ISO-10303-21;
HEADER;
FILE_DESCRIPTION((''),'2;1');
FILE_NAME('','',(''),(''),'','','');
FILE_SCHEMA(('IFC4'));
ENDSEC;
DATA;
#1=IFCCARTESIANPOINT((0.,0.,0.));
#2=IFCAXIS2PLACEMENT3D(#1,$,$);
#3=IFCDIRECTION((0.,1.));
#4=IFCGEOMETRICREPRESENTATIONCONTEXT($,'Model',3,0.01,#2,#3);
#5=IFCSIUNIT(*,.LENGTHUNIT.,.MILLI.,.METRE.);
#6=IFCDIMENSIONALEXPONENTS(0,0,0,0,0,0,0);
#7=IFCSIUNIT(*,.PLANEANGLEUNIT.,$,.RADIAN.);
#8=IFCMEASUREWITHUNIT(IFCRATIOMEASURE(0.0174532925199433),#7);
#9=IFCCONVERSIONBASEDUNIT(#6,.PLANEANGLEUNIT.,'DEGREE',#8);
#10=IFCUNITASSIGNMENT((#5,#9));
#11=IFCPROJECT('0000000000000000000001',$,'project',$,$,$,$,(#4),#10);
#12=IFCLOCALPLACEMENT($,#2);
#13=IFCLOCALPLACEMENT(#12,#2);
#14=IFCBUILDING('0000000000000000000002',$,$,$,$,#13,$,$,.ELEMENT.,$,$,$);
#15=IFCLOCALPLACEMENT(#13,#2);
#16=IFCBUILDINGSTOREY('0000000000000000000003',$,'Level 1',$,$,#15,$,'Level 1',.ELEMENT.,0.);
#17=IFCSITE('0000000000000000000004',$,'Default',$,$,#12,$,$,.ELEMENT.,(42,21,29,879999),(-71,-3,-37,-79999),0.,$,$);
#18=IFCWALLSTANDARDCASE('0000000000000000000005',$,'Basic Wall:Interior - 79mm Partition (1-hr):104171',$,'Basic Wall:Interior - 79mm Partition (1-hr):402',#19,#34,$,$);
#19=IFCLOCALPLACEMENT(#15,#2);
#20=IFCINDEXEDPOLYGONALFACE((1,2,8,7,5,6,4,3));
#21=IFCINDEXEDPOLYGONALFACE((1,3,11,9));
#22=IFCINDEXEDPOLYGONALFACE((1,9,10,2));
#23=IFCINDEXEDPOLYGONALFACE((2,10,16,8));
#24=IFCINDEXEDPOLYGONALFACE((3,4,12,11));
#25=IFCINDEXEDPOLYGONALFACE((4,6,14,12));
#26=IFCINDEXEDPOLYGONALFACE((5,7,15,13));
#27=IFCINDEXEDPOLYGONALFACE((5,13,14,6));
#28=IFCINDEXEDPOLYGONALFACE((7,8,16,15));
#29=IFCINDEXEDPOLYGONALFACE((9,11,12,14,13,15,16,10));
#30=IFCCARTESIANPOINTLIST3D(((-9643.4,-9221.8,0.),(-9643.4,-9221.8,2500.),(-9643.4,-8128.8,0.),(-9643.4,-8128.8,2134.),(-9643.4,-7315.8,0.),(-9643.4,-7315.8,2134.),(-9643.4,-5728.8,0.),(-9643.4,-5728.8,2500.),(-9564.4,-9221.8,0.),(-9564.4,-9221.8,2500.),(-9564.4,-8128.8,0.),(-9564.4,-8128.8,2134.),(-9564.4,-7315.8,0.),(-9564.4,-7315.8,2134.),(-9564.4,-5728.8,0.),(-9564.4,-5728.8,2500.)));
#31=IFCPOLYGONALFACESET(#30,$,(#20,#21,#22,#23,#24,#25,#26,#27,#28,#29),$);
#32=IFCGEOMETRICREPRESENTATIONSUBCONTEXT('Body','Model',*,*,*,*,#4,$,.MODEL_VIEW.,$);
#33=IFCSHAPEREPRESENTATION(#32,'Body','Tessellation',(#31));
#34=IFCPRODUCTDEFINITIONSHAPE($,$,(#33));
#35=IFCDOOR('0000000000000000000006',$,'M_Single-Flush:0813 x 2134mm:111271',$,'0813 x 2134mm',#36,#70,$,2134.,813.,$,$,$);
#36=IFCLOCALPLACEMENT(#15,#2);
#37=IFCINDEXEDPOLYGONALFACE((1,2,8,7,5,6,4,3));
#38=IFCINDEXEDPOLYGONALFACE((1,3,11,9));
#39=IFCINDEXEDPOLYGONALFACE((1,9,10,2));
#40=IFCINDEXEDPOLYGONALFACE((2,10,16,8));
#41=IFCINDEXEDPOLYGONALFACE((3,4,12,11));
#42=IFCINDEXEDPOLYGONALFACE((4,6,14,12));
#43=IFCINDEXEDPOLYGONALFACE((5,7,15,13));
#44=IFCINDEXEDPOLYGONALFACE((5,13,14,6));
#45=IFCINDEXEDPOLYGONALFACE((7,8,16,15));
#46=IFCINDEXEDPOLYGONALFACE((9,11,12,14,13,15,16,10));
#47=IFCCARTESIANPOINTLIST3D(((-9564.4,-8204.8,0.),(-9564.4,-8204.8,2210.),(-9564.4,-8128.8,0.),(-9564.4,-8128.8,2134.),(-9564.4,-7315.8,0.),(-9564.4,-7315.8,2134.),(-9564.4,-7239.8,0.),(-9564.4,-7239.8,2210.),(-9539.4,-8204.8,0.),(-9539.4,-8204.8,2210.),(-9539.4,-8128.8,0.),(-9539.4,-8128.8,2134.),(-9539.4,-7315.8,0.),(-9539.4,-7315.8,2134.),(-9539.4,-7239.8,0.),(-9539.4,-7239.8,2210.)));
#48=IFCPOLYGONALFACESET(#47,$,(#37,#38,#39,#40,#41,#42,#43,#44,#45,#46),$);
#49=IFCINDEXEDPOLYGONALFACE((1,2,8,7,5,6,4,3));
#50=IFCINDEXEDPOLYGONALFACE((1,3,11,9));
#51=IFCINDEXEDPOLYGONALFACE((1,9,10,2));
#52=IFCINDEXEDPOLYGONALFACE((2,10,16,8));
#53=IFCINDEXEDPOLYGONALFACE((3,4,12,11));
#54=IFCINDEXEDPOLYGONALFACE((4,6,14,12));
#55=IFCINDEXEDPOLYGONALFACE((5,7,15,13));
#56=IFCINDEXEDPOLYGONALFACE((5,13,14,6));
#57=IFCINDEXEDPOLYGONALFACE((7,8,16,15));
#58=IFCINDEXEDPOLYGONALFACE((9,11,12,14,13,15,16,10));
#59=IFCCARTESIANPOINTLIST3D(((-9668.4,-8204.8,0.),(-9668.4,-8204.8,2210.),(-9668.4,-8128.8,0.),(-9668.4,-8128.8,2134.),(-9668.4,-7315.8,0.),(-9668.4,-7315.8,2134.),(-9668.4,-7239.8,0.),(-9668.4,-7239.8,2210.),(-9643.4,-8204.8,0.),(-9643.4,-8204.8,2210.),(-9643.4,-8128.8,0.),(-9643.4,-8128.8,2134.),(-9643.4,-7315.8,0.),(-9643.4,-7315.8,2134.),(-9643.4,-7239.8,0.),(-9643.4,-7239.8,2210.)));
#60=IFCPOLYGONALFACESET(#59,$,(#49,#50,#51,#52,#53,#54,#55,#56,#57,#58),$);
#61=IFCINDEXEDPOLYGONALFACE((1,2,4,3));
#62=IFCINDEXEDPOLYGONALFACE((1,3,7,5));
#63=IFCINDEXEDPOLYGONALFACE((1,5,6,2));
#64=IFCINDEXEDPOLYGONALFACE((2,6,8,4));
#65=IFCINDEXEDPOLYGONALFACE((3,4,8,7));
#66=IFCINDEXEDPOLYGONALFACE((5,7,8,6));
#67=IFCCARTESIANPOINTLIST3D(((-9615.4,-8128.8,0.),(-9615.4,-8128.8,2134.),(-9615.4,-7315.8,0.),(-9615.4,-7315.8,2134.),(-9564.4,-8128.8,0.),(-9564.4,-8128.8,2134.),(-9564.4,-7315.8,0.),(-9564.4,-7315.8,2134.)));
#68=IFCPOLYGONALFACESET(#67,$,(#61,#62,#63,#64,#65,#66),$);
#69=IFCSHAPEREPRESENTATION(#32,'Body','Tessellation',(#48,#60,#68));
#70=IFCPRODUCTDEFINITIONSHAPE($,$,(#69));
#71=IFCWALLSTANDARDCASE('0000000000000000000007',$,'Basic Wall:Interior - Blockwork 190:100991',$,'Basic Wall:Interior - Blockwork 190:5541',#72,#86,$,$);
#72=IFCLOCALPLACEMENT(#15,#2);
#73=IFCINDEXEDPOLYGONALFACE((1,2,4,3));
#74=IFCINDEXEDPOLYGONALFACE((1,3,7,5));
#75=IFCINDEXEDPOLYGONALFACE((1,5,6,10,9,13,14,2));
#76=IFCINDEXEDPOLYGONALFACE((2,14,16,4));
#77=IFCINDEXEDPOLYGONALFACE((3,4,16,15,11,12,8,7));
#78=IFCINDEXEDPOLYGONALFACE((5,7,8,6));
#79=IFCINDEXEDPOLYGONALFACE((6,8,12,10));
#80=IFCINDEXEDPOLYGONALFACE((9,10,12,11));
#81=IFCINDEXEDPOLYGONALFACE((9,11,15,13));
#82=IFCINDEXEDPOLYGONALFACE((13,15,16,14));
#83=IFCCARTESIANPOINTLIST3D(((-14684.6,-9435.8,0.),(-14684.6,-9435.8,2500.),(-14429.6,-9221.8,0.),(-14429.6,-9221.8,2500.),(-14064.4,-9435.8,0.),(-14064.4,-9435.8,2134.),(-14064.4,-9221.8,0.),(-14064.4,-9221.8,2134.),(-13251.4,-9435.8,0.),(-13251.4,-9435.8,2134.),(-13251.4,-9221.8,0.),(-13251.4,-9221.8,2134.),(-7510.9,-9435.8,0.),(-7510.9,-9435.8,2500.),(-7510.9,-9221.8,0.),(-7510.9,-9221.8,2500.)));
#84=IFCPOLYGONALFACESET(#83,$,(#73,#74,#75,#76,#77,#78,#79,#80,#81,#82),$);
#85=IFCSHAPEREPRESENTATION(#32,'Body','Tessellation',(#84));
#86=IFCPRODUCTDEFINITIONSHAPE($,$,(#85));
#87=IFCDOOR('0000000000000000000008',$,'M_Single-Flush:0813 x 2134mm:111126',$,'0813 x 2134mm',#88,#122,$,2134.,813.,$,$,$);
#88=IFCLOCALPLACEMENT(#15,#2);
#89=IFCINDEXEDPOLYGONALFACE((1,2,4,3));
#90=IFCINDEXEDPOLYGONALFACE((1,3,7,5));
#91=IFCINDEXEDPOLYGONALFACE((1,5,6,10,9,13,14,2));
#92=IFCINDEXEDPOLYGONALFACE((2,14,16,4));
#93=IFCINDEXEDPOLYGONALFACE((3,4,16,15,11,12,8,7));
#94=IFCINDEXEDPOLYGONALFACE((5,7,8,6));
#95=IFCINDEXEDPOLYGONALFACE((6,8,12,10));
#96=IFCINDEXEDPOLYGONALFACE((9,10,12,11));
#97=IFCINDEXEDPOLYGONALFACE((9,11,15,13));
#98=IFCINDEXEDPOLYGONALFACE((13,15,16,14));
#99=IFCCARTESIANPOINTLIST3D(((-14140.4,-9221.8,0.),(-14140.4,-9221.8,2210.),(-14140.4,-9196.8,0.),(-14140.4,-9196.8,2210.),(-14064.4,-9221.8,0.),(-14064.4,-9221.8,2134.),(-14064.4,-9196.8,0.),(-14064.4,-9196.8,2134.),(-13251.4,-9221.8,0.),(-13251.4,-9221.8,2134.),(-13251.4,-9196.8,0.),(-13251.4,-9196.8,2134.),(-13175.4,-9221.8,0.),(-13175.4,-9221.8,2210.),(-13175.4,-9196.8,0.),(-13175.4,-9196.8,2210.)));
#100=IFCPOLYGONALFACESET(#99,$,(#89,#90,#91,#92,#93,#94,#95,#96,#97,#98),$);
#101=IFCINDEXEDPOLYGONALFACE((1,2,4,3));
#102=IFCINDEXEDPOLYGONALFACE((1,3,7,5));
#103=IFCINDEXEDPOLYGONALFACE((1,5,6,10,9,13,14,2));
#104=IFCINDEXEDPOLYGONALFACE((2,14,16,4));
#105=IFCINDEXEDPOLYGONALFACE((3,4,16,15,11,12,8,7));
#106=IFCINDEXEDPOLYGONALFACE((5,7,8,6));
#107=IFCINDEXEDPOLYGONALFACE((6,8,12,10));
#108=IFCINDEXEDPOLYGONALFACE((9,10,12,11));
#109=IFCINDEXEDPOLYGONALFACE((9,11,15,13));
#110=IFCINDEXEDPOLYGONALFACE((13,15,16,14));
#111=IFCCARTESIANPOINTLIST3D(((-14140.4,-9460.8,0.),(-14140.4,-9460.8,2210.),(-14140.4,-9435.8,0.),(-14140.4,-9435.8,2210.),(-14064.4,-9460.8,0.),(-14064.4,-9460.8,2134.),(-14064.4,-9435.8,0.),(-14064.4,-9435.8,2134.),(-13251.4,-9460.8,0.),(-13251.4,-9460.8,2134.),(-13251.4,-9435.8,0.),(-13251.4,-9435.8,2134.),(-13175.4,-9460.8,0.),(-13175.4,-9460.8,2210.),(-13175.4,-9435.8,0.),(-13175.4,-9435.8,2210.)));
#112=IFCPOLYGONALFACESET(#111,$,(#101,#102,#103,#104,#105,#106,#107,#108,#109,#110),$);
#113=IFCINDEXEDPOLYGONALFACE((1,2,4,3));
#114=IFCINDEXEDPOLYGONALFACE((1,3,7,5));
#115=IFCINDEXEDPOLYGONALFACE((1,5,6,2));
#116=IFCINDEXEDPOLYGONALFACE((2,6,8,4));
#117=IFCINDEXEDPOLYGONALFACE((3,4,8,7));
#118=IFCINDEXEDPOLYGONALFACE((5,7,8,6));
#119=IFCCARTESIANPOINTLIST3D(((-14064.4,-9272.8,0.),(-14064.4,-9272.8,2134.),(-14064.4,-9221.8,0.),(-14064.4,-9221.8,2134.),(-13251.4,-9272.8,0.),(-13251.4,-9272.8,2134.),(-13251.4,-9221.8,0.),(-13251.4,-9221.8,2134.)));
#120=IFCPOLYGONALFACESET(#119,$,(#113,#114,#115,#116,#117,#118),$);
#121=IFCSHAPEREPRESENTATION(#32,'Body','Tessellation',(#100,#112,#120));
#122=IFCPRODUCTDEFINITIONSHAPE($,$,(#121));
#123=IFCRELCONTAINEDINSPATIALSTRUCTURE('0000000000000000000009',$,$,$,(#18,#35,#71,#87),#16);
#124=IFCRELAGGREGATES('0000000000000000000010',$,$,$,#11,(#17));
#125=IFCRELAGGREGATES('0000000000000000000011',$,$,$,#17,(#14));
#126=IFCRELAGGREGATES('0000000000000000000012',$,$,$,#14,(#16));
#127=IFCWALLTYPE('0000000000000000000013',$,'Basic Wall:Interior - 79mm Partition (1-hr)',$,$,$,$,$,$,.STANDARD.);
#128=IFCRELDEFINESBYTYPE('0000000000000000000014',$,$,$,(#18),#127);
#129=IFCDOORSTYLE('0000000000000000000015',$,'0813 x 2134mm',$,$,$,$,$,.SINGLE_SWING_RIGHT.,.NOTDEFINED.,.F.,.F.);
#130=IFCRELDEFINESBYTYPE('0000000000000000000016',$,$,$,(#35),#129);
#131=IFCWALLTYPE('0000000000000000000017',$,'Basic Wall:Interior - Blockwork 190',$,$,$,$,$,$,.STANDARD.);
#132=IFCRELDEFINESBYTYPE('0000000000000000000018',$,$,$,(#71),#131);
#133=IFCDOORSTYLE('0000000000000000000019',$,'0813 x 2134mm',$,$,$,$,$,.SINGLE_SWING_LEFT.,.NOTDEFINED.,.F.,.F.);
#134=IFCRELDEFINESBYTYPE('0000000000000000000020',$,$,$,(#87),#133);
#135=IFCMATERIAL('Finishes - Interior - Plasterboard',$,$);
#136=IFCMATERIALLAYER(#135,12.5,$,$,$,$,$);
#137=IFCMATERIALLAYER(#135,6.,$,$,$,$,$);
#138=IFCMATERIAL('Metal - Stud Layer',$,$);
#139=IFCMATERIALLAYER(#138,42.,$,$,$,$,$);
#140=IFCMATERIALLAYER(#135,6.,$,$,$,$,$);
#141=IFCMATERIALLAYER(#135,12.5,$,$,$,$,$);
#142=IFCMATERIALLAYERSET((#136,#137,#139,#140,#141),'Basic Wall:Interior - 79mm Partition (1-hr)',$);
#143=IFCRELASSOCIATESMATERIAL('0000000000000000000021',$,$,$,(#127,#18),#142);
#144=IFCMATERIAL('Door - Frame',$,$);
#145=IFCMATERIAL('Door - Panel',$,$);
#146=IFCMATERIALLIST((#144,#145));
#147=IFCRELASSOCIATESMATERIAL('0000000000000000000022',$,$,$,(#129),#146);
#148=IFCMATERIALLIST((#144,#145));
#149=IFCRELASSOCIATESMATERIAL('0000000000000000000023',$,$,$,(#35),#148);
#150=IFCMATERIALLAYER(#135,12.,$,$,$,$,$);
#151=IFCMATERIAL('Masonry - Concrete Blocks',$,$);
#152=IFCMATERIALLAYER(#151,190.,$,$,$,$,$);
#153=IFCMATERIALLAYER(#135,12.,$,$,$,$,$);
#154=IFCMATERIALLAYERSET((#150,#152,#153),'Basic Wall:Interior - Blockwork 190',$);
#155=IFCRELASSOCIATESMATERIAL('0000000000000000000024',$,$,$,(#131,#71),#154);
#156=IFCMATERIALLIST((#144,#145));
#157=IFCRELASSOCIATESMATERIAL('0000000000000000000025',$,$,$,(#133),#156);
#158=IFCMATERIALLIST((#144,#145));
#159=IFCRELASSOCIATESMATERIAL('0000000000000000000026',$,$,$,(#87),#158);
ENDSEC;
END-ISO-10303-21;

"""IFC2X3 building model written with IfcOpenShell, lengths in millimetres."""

from ifc_helpers import new_model, entity, si_unit, converted_unit, direction, frame, frame_2d, origin, origin_2d_with_axis, place, context, subcontext, project, spatial, polyline, rectangle, outline, extrude, source, transform, mapped, material, material_list, layer, layer_set, layer_usage, type_object, type_shapes, element, fill, save


model = new_model("IFC2X3")

# Units and contexts
model_context = context("Model", 3, precision=0.01, world=origin(), true_north=direction((0.0, 1.0)))
body_context = subcontext(model_context, "Body", "Model", "MODEL_VIEW")
ifc_project = project(units=[si_unit("LENGTHUNIT", "METRE", prefix="MILLI"), converted_unit("PLANEANGLEUNIT", "DEGREE", entity("IfcRatioMeasure", 0.0174532925199433), si_unit("PLANEANGLEUNIT", "RADIAN"), dimensions=[0, 0, 0, 0, 0, 0, 0])], contexts=[model_context])

# Site, building, storey
site_placement = place(None, origin())
site = spatial("IfcSite", under=ifc_project, at=site_placement, Name="Default", CompositionType="ELEMENT", RefLatitude=(42, 21, 29, 879999), RefLongitude=(-71, -3, -37, -79999), RefElevation=0.0)
building_placement = place(site_placement, origin())
building = spatial("IfcBuilding", under=site, at=building_placement, CompositionType="ELEMENT")
storey_placement = place(building_placement, origin())
storey = spatial("IfcBuildingStorey", under=building, at=storey_placement, Name="Level 1", LongName="Level 1", CompositionType="ELEMENT", Elevation=0.0)

# Shared definitions
ifc_material_1 = material(Name="Door - Frame")
ifc_material_2 = material(Name="Door - Panel")

# Shared definitions
ifc_material_3 = material(Name="Finishes - Interior - Plasterboard")
ifc_layer_1 = layer(ifc_material_3, 12.5)
ifc_layer_2 = layer(ifc_material_3, 6.0)
ifc_material_4 = material(Name="Metal - Stud Layer")
ifc_layer_3 = layer(ifc_material_4, 42.0)
ifc_layer_4 = layer(ifc_material_3, 6.0)
ifc_layer_5 = layer(ifc_material_3, 12.5)
ifc_layer_set_1 = layer_set([ifc_layer_1, ifc_layer_2, ifc_layer_3, ifc_layer_4, ifc_layer_5], Name="Basic Wall:Interior - 79mm Partition (1-hr)")
wall_type_1 = type_object("IfcWallType", Name="Basic Wall:Interior - 79mm Partition (1-hr)", PredefinedType="STANDARD", material=ifc_layer_set_1)

# Walls, openings, doors
ifc_layer_usage_1 = layer_usage(ifc_layer_set_1, "AXIS2", "NEGATIVE", 39.5)
wall_1_placement = place(storey_placement, frame((-9603.9, -9221.8, 0.0), z_axis=(0.0, 0.0, 1.0), x_axis=(0.0, 1.0, 0.0)))
wall_1 = element("IfcWallStandardCase", 1, at=wall_1_placement, inside=storey, type_object=wall_type_1, material=ifc_layer_usage_1, Name="Basic Wall:Interior - 79mm Partition (1-hr):104171", ObjectType="Basic Wall:Interior - 79mm Partition (1-hr):402", context=body_context, shape_type="SweptSolid", body=[
    extrude(rectangle(XDim=3493.0, YDim=79.0, at=frame_2d((1746.5, 0.0), x_axis=(-1.0, 0.0))), origin(), (0.0, 0.0, 1.0), 2500.0),
])
opening_1_placement = place(wall_1_placement, frame((1906.0, 39.5, 0.0)))
opening_1 = element("IfcOpeningElement", 2, at=opening_1_placement, cuts=wall_1, ObjectType="Opening", context=body_context, shape_type="SweptSolid", body=[
    extrude(rectangle(XDim=813.0, YDim=2134.0, at=frame_2d((1067.0, 406.5), x_axis=(0.0, 1.0))), frame((0.0, 0.0, 0.0), z_axis=(0.0, -1.0, 0.0), x_axis=(0.0, 0.0, 1.0)), (0.0, 0.0, 1.0), 79.0),
])
ifc_material_list_1 = material_list([ifc_material_1, ifc_material_2])
ifc_material_list_2 = material_list([ifc_material_1, ifc_material_2])
door_style_1 = type_object("IfcDoorStyle", Name="0813 x 2134mm", ConstructionType="NOTDEFINED", OperationType="SINGLE_SWING_RIGHT", ParameterTakesPrecedence=False, Sizeable=False, material=ifc_material_list_2)
shared_shape_1 = source(origin(), body_context, "Body", "SweptSolid", [
    extrude(outline(polyline([(-482.5, -1124.0), (482.5, -1124.0), (482.5, 1086.0), (406.5, 1086.0), (406.5, -1048.0), (-406.5, -1048.0), (-406.5, 1086.0), (-482.5, 1086.0), (-482.5, -1124.0)])), frame((406.5, 79.0, 1086.0), z_axis=(0.0, 1.0, 0.0), x_axis=(1.0, 0.0, 0.0)), (0.0, 0.0, 1.0), 25.0),
    extrude(outline(polyline([(-1124.0, -482.5), (1086.0, -482.5), (1086.0, -406.5), (-1048.0, -406.5), (-1048.0, 406.5), (1086.0, 406.5), (1086.0, 482.5), (-1124.0, 482.5), (-1124.0, -482.5)])), frame((406.5, -25.0, 1086.0), z_axis=(0.0, 1.0, 0.0), x_axis=(0.0, 0.0, -1.0)), (0.0, 0.0, 1.0), 25.0),
    extrude(rectangle(XDim=51.0, YDim=813.0, at=origin_2d_with_axis()), frame((406.5, 53.5, 0.0), z_axis=(0.0, 0.0, 1.0), x_axis=(0.0, 1.0, 0.0)), (0.0, 0.0, 1.0), 2134.0),
])
type_shapes(door_style_1, [shared_shape_1])
door_1_placement = place(opening_1_placement, frame((0.0, 0.0, 0.0), z_axis=(0.0, 0.0, 1.0), x_axis=(-1.0, 0.0, 0.0)))
door_1 = element("IfcDoor", 3, at=door_1_placement, inside=storey, type_object=door_style_1, material=ifc_material_list_1, Name="M_Single-Flush:0813 x 2134mm:111271", ObjectType="0813 x 2134mm", OverallHeight=2134.0, OverallWidth=813.0, context=body_context, shape_type="MappedRepresentation", body=[
    mapped(shared_shape_1, transform((0.0, 0.0, 0.0), scale=1.0)),
])
fill(opening_1, door_1)
ifc_layer_6 = layer(ifc_material_3, 12.0)
ifc_material_5 = material(Name="Masonry - Concrete Blocks")
ifc_layer_7 = layer(ifc_material_5, 190.0)
ifc_layer_8 = layer(ifc_material_3, 12.0)
ifc_layer_set_2 = layer_set([ifc_layer_6, ifc_layer_7, ifc_layer_8], Name="Basic Wall:Interior - Blockwork 190")
ifc_layer_usage_2 = layer_usage(ifc_layer_set_2, "AXIS2", "NEGATIVE", 107.0)
wall_type_2 = type_object("IfcWallType", Name="Basic Wall:Interior - Blockwork 190", PredefinedType="STANDARD", material=ifc_layer_set_2)
wall_2_placement = place(storey_placement, frame((-7510.9, -9328.8, 0.0), z_axis=(0.0, 0.0, 1.0), x_axis=(-1.0, 0.0, 0.0)))
wall_2 = element("IfcWallStandardCase", 4, at=wall_2_placement, inside=storey, type_object=wall_type_2, material=ifc_layer_usage_2, Name="Basic Wall:Interior - Blockwork 190:100991", ObjectType="Basic Wall:Interior - Blockwork 190:5541", context=body_context, shape_type="SweptSolid", body=[
    extrude(outline(polyline([(0.0, -107.0), (6918.7, -107.0), (7173.7, 107.0), (0.0, 107.0), (0.0, -107.0)])), origin(), (0.0, 0.0, 1.0), 2500.0),
])
opening_2_placement = place(wall_2_placement, frame((6553.5, 107.0, 0.0)))
opening_2 = element("IfcOpeningElement", 5, at=opening_2_placement, cuts=wall_2, ObjectType="Opening", context=body_context, shape_type="SweptSolid", body=[
    extrude(rectangle(XDim=813.0, YDim=2134.0, at=frame_2d((1067.0, 406.5), x_axis=(0.0, -1.0))), frame((0.0, 0.0, 0.0), z_axis=(0.0, -1.0, 0.0), x_axis=(0.0, 0.0, 1.0)), (0.0, 0.0, 1.0), 214.0),
])
ifc_material_list_3 = material_list([ifc_material_1, ifc_material_2])
ifc_material_list_4 = material_list([ifc_material_1, ifc_material_2])
door_style_2 = type_object("IfcDoorStyle", Name="0813 x 2134mm", ConstructionType="NOTDEFINED", OperationType="SINGLE_SWING_LEFT", ParameterTakesPrecedence=False, Sizeable=False, material=ifc_material_list_4)
shared_shape_2 = source(origin(), body_context, "Body", "SweptSolid", [
    extrude(outline(polyline([(-482.5, -1124.0), (482.5, -1124.0), (482.5, 1086.0), (406.5, 1086.0), (406.5, -1048.0), (-406.5, -1048.0), (-406.5, 1086.0), (-482.5, 1086.0), (-482.5, -1124.0)])), frame((406.5, 239.0, 1086.0), z_axis=(0.0, -1.0, 0.0), x_axis=(-1.0, 0.0, 0.0)), (0.0, 0.0, 1.0), 25.0),
    extrude(outline(polyline([(-1124.0, -482.5), (1086.0, -482.5), (1086.0, -406.5), (-1048.0, -406.5), (-1048.0, 406.5), (1086.0, 406.5), (1086.0, 482.5), (-1124.0, 482.5), (-1124.0, -482.5)])), frame((406.5, 0.0, 1086.0), z_axis=(0.0, -1.0, 0.0), x_axis=(0.0, 0.0, -1.0)), (0.0, 0.0, 1.0), 25.0),
    extrude(rectangle(XDim=813.0, YDim=51.0, at=frame_2d((0.0, 0.0), x_axis=(1.0, 0.0))), frame((406.5, 188.5, 0.0)), (0.0, 0.0, 1.0), 2134.0),
])
type_shapes(door_style_2, [shared_shape_2])
door_2_placement = place(opening_2_placement, frame((0.0, 0.0, 0.0), z_axis=(0.0, 0.0, 1.0), x_axis=(-1.0, 0.0, 0.0)))
door_2 = element("IfcDoor", 6, at=door_2_placement, inside=storey, type_object=door_style_2, material=ifc_material_list_3, Name="M_Single-Flush:0813 x 2134mm:111126", ObjectType="0813 x 2134mm", OverallHeight=2134.0, OverallWidth=813.0, context=body_context, shape_type="MappedRepresentation", body=[
    mapped(shared_shape_2, transform((0.0, 0.0, 0.0), scale=1.0)),
])
fill(opening_2, door_2)

save(model, "model.ifc")
